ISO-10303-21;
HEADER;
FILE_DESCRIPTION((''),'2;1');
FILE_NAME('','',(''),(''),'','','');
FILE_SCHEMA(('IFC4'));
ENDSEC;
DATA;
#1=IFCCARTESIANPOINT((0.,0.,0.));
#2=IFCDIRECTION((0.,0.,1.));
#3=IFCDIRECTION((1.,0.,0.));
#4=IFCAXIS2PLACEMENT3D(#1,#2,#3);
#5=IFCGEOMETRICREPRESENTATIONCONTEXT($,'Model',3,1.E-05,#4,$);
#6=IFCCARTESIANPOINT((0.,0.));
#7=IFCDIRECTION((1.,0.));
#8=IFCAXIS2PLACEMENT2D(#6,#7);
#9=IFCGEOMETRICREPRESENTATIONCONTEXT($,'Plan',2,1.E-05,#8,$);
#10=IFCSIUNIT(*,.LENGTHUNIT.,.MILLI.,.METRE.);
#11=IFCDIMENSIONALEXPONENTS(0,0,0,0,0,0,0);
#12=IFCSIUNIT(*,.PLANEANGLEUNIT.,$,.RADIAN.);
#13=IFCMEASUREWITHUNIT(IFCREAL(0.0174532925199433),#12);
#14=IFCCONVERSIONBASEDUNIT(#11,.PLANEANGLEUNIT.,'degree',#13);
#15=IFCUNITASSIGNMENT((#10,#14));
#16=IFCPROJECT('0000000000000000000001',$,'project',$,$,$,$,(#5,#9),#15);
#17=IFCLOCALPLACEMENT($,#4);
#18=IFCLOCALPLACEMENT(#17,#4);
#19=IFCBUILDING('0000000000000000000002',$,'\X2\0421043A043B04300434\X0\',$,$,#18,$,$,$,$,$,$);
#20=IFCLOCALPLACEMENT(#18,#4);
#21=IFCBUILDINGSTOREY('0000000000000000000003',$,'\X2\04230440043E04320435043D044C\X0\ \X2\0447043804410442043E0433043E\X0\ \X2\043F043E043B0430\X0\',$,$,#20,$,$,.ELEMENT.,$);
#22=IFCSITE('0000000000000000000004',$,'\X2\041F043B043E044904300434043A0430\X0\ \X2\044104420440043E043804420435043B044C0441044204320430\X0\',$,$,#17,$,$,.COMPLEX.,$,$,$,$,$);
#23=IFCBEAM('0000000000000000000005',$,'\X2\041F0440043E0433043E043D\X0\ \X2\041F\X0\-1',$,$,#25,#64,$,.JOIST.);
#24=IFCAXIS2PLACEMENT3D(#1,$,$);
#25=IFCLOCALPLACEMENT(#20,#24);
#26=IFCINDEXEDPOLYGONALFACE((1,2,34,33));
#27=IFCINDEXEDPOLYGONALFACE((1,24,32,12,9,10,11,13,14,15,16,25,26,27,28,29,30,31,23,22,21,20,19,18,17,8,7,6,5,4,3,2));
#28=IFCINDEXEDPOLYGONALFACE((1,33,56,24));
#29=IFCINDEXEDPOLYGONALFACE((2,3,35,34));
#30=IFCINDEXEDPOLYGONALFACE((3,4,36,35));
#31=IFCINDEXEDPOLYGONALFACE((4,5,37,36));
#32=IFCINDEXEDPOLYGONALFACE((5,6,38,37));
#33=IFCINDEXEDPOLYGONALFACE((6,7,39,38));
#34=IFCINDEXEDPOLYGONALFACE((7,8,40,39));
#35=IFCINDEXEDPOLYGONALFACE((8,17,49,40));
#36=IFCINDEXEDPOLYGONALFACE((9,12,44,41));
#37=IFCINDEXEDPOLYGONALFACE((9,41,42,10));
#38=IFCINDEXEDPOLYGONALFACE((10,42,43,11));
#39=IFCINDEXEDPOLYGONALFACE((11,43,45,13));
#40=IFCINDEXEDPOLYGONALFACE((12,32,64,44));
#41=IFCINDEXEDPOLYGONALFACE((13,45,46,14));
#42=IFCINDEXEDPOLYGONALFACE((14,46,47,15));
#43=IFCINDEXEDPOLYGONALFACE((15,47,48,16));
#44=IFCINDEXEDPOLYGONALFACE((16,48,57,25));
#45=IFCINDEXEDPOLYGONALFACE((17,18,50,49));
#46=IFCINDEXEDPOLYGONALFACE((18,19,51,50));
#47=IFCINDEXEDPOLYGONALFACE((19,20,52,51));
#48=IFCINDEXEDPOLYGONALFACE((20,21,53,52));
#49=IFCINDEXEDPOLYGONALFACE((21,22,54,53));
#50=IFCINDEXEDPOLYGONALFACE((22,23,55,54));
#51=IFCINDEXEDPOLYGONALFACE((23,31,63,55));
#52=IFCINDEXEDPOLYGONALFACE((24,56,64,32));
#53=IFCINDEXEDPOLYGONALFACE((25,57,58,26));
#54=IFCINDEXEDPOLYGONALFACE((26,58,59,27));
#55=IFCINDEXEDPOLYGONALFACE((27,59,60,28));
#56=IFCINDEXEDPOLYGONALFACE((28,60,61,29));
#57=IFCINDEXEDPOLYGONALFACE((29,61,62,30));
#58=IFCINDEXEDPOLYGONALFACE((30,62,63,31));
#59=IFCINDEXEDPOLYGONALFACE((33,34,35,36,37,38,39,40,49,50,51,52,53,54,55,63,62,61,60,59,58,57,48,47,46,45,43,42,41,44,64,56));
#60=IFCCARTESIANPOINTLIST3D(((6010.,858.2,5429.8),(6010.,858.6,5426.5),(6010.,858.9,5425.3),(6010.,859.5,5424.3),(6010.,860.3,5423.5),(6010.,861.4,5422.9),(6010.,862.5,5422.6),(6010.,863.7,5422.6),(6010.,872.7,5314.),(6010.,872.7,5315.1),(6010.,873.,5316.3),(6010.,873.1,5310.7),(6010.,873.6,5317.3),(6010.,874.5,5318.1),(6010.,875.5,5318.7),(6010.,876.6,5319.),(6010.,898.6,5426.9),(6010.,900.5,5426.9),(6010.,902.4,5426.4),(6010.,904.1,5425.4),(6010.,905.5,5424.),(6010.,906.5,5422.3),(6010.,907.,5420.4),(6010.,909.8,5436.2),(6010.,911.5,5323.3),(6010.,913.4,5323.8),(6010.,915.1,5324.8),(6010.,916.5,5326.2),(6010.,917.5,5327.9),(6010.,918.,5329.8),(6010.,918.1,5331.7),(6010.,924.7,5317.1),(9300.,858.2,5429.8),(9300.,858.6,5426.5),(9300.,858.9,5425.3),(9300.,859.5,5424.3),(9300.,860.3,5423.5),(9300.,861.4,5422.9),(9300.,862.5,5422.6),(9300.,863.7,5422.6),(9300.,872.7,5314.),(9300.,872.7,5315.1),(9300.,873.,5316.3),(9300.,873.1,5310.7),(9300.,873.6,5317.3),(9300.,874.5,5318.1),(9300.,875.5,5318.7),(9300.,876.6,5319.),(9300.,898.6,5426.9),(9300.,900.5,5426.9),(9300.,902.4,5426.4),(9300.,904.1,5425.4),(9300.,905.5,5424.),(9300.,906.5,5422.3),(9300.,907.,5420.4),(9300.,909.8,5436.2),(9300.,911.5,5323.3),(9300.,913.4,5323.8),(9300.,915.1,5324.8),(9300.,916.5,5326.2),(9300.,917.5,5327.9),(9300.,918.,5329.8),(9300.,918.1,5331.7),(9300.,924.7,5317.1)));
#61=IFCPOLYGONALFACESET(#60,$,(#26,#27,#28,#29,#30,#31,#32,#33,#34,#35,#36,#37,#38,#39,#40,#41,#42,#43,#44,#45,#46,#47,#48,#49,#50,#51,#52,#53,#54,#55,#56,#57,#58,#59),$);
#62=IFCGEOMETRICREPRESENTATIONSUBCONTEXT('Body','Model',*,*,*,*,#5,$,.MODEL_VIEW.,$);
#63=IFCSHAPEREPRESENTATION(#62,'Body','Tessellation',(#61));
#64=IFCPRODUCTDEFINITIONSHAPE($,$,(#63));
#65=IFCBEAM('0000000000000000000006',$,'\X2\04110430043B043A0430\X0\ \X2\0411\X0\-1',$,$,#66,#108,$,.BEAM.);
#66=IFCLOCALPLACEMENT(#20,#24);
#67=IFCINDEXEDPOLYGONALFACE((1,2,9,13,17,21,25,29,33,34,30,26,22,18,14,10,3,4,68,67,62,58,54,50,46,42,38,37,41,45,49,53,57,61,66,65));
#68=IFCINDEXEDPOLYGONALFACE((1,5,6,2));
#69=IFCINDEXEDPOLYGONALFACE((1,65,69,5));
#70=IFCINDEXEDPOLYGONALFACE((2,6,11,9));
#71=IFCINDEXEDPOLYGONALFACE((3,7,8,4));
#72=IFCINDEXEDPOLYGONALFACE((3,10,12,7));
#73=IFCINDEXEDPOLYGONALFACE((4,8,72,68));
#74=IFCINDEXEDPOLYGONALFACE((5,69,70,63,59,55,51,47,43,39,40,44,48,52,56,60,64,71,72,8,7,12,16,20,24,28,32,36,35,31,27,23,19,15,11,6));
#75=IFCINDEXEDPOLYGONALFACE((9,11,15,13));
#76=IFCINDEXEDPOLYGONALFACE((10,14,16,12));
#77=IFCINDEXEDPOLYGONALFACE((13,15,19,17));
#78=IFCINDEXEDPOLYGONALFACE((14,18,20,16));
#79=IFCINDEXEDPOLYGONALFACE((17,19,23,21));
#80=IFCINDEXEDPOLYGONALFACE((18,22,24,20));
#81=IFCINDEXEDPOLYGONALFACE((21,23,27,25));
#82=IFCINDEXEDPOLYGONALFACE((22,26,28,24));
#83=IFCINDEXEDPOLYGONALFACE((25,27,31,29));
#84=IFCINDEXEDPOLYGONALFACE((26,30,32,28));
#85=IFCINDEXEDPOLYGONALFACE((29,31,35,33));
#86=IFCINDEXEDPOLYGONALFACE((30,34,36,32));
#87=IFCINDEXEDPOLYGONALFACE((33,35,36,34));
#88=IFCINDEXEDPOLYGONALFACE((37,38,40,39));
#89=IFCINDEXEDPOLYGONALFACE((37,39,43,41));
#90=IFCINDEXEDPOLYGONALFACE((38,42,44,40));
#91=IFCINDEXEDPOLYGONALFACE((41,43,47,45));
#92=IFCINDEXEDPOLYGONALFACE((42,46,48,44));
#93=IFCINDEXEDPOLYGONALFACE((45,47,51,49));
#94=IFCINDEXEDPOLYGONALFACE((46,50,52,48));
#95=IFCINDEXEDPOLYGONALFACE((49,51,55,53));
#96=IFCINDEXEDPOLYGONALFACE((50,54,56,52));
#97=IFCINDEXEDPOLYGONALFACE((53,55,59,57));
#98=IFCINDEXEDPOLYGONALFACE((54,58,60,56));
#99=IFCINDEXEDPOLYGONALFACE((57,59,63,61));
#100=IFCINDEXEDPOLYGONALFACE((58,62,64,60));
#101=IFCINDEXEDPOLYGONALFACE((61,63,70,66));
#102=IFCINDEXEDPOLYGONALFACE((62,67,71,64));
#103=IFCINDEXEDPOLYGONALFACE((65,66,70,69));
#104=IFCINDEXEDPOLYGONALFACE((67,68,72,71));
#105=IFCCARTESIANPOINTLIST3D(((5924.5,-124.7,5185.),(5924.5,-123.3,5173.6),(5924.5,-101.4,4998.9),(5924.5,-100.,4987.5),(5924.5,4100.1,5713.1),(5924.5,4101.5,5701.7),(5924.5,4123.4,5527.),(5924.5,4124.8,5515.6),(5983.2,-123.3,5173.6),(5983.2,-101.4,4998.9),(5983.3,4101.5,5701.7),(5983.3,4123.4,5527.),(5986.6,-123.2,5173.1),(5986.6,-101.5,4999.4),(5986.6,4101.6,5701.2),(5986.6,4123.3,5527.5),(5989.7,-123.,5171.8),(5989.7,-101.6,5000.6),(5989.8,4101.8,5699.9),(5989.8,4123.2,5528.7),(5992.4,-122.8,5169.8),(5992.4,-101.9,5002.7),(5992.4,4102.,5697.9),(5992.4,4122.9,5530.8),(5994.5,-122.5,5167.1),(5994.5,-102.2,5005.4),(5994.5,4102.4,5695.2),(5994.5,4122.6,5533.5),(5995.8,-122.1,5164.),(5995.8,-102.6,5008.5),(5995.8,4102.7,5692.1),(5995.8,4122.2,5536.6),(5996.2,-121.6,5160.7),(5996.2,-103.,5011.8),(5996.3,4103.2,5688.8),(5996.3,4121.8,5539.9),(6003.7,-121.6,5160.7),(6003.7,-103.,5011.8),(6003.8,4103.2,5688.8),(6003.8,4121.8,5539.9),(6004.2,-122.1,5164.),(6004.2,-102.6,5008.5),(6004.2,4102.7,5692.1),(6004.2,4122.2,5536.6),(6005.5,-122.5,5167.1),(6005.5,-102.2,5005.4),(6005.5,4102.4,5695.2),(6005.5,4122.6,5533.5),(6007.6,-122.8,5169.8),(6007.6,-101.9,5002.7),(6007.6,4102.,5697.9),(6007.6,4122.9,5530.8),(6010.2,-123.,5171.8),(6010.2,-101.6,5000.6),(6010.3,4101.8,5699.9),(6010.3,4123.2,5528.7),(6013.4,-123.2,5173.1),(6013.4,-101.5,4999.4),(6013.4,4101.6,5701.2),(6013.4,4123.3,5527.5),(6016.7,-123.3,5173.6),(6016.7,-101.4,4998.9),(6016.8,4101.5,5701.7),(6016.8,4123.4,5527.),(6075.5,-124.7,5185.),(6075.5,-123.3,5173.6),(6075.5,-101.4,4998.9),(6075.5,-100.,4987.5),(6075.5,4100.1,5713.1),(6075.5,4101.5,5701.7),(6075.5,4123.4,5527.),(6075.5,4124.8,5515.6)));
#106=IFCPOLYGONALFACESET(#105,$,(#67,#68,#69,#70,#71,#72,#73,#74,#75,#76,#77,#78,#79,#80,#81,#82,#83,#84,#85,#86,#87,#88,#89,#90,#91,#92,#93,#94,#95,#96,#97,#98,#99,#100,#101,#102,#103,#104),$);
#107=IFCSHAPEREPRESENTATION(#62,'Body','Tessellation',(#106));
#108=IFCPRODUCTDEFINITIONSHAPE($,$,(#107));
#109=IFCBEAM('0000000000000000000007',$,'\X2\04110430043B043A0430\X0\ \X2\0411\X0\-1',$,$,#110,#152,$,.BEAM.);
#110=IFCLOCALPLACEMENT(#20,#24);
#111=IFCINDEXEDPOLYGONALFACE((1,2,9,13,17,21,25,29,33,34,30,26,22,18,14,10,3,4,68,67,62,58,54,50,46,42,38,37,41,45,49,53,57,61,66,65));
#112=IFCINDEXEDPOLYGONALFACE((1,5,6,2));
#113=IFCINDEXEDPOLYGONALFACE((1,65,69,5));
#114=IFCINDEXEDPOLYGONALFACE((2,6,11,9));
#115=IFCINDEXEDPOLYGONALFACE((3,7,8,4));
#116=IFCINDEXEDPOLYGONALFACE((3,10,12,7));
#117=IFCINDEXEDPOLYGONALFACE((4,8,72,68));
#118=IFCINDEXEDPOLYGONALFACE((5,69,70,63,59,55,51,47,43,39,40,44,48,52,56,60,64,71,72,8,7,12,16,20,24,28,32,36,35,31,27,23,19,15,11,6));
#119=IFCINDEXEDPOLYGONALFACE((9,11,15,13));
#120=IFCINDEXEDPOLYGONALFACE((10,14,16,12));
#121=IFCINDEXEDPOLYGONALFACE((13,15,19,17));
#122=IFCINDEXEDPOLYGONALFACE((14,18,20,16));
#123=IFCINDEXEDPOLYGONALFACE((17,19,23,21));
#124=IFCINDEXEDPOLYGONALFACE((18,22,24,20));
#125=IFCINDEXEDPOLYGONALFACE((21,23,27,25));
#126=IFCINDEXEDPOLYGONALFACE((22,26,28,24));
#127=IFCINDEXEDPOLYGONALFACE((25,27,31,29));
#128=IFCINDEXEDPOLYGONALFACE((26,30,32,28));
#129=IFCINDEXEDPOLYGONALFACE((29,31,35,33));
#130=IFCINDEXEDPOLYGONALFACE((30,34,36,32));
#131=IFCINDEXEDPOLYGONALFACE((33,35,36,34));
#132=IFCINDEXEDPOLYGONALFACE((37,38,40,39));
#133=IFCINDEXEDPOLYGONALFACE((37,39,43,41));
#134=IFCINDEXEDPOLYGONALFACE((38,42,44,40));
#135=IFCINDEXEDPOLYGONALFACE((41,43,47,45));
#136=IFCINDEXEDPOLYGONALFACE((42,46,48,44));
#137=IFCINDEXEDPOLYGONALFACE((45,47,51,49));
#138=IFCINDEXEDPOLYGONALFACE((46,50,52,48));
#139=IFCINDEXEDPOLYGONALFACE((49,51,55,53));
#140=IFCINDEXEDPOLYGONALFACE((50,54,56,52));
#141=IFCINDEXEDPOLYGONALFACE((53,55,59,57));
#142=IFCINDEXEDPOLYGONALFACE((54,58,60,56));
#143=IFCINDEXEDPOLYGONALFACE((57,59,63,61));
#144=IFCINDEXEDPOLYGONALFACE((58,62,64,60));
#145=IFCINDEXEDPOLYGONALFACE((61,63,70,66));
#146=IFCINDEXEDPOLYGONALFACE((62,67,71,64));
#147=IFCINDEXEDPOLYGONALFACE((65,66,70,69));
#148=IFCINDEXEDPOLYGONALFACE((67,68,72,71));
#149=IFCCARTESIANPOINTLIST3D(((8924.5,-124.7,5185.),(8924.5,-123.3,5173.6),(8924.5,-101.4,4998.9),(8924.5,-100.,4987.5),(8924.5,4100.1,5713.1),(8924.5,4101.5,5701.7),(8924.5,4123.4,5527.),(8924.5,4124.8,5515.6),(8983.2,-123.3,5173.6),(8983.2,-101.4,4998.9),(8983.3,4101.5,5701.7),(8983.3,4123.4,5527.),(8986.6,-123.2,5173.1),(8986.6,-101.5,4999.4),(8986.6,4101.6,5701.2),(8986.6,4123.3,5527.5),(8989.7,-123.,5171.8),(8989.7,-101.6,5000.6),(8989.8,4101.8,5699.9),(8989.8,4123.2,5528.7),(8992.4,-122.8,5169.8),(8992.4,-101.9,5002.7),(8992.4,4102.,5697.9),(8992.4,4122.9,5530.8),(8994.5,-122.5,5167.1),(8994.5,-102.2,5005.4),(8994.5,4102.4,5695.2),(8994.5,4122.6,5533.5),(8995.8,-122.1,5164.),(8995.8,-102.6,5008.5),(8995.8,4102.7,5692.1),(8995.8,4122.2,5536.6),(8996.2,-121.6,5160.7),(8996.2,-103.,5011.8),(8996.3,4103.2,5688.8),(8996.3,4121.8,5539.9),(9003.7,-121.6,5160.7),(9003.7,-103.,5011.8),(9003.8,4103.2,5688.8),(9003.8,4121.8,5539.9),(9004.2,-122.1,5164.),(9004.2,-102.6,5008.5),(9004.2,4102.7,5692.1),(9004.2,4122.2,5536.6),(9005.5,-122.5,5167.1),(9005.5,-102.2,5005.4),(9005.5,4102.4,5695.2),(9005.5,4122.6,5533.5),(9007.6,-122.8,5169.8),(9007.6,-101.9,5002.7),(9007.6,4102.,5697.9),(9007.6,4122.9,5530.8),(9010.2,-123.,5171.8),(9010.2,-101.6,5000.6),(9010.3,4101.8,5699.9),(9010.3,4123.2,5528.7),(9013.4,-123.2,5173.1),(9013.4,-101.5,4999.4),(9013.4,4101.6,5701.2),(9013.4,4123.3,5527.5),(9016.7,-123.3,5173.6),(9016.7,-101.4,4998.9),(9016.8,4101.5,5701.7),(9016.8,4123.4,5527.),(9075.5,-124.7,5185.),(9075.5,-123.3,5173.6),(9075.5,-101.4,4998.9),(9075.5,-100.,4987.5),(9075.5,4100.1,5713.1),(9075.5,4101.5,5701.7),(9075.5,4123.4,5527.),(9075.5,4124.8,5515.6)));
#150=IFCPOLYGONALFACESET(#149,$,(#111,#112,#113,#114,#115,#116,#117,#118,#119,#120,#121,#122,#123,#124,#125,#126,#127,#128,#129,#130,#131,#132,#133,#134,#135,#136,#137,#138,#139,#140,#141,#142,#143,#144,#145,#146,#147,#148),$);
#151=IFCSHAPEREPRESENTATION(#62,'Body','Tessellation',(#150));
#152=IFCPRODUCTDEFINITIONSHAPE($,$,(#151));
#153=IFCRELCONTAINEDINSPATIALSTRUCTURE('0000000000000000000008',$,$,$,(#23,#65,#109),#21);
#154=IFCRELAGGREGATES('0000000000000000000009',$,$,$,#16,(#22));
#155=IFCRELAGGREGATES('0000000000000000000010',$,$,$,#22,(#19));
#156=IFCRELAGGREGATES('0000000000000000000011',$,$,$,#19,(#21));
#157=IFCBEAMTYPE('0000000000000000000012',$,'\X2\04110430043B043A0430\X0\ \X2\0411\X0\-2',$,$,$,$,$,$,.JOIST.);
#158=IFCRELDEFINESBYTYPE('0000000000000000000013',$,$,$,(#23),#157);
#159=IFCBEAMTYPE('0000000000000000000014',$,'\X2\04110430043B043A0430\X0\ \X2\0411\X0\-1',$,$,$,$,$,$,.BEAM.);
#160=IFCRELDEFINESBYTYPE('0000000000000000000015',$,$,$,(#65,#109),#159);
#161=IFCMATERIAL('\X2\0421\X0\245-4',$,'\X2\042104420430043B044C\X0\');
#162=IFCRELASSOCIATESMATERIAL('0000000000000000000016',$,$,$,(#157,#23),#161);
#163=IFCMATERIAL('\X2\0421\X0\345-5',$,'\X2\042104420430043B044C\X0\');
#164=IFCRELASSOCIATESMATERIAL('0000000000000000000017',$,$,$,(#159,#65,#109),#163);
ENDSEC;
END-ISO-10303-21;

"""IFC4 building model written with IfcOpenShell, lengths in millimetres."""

from ifc_helpers import new_model, entity, si_unit, converted_unit, frame, origin_with_axes, origin_2d_with_axis, place, context, subcontext, project, spatial, i_section, u_section, extrude, material, material_profile, profile_set, profile_usage, type_object, element, save


model = new_model("IFC4")

# Units and contexts
model_context = context("Model", 3, precision=1e-05, world=origin_with_axes())
plan_context = context("Plan", 2, precision=1e-05, world=origin_2d_with_axis())
body_context = subcontext(model_context, "Body", "Model", "MODEL_VIEW")
ifc_project = project(units=[si_unit("LENGTHUNIT", "METRE", prefix="MILLI"), converted_unit("PLANEANGLEUNIT", "degree", entity("IfcReal", 0.0174532925199433), si_unit("PLANEANGLEUNIT", "RADIAN"), dimensions=[0, 0, 0, 0, 0, 0, 0])], contexts=[model_context, plan_context])

# Site, building, storey
site_placement = place(None, origin_with_axes())
site = spatial("IfcSite", under=ifc_project, at=site_placement, Name="Площадка строительства", CompositionType="COMPLEX")
building_placement = place(site_placement, origin_with_axes())
building = spatial("IfcBuilding", under=site, at=building_placement, Name="Склад")
storey_placement = place(building_placement, origin_with_axes())
storey = spatial("IfcBuildingStorey", under=building, at=storey_placement, Name="Уровень чистого пола", CompositionType="ELEMENT")

# Shared definitions
ifc_material_1 = material(Name="С345-5", Category="Сталь")

# Beams
ifc_material_2 = material(Name="С245-4", Category="Сталь")
ifc_material_profile_1 = material_profile(ifc_material_2, u_section(Depth=120.0, FlangeWidth=52.0, WebThickness=4.8, FlangeThickness=7.8, FilletRadius=7.5, EdgeRadius=4.5, FlangeSlope=0.0))
ifc_profile_set_1 = profile_set([ifc_material_profile_1], Name="U12P_S245-4")
beam_type_1 = type_object("IfcBeamType", Name="Балка Б-2", PredefinedType="JOIST", material=ifc_profile_set_1)
ifc_profile_usage_1 = profile_usage(ifc_profile_set_1, cardinal=3)
beam_1_placement = place(storey_placement, frame((9300.0, 924.7, 5317.1), z_axis=(-1.0, 0.0, 0.0), x_axis=(0.0, -0.99228, -0.12402)))
element("IfcBeam", 1, at=beam_1_placement, inside=storey, type_object=beam_type_1, material=ifc_profile_usage_1, Name="Прогон П-1", PredefinedType="JOIST", context=body_context, shape_type="SweptSolid", body=[
    extrude(u_section(Depth=120.0, FlangeWidth=52.0, WebThickness=4.8, FlangeThickness=7.8, FilletRadius=7.5, EdgeRadius=4.5, FlangeSlope=0.0), frame((26.0, 60.0, 0.0), z_axis=(0.0, 0.0, 1.0), x_axis=(1.0, 0.0, 0.0)), (0.0, 0.0, 1.0), 3290.0),
])
ifc_material_profile_2 = material_profile(ifc_material_1, i_section(OverallWidth=151.0, OverallDepth=199.0, WebThickness=7.5, FlangeThickness=11.5, FilletRadius=13.0, FlangeEdgeRadius=0.0, FlangeSlope=0.0))
ifc_profile_set_2 = profile_set([ifc_material_profile_2], Name="I20H2_S345-5")
ifc_profile_usage_2 = profile_usage(ifc_profile_set_2, cardinal=2)
beam_type_2 = type_object("IfcBeamType", Name="Балка Б-1", PredefinedType="BEAM", material=ifc_profile_set_2)
beam_2_placement = place(storey_placement, frame((6000.0, -100.0, 4987.5), z_axis=(0.0, 0.992278, 0.124035), x_axis=(-1.0, 0.0, 0.0)))
element("IfcBeam", 2, at=beam_2_placement, inside=storey, type_object=beam_type_2, material=ifc_profile_usage_2, Name="Балка Б-1", PredefinedType="BEAM", context=body_context, shape_type="SweptSolid", body=[
    extrude(i_section(OverallWidth=151.0, OverallDepth=199.0, WebThickness=7.5, FlangeThickness=11.5, FilletRadius=13.0, FlangeEdgeRadius=0.0, FlangeSlope=0.0), frame((0.0, 99.5, 0.0), z_axis=(0.0, 0.0, 1.0), x_axis=(1.0, 0.0, 0.0)), (0.0, 0.0, 1.0), 4257.7),
])
ifc_profile_usage_3 = profile_usage(ifc_profile_set_2, cardinal=2)
beam_3_placement = place(storey_placement, frame((9000.0, -100.0, 4987.5), z_axis=(0.0, 0.992278, 0.124035), x_axis=(-1.0, 0.0, 0.0)))
element("IfcBeam", 3, at=beam_3_placement, inside=storey, type_object=beam_type_2, material=ifc_profile_usage_3, Name="Балка Б-1", PredefinedType="BEAM", context=body_context, shape_type="SweptSolid", body=[
    extrude(i_section(OverallWidth=151.0, OverallDepth=199.0, WebThickness=7.5, FlangeThickness=11.5, FilletRadius=13.0, FlangeEdgeRadius=0.0, FlangeSlope=0.0), frame((0.0, 99.5, 0.0), z_axis=(0.0, 0.0, 1.0), x_axis=(1.0, 0.0, 0.0)), (0.0, 0.0, 1.0), 4257.7),
])

save(model, "model.ifc")
